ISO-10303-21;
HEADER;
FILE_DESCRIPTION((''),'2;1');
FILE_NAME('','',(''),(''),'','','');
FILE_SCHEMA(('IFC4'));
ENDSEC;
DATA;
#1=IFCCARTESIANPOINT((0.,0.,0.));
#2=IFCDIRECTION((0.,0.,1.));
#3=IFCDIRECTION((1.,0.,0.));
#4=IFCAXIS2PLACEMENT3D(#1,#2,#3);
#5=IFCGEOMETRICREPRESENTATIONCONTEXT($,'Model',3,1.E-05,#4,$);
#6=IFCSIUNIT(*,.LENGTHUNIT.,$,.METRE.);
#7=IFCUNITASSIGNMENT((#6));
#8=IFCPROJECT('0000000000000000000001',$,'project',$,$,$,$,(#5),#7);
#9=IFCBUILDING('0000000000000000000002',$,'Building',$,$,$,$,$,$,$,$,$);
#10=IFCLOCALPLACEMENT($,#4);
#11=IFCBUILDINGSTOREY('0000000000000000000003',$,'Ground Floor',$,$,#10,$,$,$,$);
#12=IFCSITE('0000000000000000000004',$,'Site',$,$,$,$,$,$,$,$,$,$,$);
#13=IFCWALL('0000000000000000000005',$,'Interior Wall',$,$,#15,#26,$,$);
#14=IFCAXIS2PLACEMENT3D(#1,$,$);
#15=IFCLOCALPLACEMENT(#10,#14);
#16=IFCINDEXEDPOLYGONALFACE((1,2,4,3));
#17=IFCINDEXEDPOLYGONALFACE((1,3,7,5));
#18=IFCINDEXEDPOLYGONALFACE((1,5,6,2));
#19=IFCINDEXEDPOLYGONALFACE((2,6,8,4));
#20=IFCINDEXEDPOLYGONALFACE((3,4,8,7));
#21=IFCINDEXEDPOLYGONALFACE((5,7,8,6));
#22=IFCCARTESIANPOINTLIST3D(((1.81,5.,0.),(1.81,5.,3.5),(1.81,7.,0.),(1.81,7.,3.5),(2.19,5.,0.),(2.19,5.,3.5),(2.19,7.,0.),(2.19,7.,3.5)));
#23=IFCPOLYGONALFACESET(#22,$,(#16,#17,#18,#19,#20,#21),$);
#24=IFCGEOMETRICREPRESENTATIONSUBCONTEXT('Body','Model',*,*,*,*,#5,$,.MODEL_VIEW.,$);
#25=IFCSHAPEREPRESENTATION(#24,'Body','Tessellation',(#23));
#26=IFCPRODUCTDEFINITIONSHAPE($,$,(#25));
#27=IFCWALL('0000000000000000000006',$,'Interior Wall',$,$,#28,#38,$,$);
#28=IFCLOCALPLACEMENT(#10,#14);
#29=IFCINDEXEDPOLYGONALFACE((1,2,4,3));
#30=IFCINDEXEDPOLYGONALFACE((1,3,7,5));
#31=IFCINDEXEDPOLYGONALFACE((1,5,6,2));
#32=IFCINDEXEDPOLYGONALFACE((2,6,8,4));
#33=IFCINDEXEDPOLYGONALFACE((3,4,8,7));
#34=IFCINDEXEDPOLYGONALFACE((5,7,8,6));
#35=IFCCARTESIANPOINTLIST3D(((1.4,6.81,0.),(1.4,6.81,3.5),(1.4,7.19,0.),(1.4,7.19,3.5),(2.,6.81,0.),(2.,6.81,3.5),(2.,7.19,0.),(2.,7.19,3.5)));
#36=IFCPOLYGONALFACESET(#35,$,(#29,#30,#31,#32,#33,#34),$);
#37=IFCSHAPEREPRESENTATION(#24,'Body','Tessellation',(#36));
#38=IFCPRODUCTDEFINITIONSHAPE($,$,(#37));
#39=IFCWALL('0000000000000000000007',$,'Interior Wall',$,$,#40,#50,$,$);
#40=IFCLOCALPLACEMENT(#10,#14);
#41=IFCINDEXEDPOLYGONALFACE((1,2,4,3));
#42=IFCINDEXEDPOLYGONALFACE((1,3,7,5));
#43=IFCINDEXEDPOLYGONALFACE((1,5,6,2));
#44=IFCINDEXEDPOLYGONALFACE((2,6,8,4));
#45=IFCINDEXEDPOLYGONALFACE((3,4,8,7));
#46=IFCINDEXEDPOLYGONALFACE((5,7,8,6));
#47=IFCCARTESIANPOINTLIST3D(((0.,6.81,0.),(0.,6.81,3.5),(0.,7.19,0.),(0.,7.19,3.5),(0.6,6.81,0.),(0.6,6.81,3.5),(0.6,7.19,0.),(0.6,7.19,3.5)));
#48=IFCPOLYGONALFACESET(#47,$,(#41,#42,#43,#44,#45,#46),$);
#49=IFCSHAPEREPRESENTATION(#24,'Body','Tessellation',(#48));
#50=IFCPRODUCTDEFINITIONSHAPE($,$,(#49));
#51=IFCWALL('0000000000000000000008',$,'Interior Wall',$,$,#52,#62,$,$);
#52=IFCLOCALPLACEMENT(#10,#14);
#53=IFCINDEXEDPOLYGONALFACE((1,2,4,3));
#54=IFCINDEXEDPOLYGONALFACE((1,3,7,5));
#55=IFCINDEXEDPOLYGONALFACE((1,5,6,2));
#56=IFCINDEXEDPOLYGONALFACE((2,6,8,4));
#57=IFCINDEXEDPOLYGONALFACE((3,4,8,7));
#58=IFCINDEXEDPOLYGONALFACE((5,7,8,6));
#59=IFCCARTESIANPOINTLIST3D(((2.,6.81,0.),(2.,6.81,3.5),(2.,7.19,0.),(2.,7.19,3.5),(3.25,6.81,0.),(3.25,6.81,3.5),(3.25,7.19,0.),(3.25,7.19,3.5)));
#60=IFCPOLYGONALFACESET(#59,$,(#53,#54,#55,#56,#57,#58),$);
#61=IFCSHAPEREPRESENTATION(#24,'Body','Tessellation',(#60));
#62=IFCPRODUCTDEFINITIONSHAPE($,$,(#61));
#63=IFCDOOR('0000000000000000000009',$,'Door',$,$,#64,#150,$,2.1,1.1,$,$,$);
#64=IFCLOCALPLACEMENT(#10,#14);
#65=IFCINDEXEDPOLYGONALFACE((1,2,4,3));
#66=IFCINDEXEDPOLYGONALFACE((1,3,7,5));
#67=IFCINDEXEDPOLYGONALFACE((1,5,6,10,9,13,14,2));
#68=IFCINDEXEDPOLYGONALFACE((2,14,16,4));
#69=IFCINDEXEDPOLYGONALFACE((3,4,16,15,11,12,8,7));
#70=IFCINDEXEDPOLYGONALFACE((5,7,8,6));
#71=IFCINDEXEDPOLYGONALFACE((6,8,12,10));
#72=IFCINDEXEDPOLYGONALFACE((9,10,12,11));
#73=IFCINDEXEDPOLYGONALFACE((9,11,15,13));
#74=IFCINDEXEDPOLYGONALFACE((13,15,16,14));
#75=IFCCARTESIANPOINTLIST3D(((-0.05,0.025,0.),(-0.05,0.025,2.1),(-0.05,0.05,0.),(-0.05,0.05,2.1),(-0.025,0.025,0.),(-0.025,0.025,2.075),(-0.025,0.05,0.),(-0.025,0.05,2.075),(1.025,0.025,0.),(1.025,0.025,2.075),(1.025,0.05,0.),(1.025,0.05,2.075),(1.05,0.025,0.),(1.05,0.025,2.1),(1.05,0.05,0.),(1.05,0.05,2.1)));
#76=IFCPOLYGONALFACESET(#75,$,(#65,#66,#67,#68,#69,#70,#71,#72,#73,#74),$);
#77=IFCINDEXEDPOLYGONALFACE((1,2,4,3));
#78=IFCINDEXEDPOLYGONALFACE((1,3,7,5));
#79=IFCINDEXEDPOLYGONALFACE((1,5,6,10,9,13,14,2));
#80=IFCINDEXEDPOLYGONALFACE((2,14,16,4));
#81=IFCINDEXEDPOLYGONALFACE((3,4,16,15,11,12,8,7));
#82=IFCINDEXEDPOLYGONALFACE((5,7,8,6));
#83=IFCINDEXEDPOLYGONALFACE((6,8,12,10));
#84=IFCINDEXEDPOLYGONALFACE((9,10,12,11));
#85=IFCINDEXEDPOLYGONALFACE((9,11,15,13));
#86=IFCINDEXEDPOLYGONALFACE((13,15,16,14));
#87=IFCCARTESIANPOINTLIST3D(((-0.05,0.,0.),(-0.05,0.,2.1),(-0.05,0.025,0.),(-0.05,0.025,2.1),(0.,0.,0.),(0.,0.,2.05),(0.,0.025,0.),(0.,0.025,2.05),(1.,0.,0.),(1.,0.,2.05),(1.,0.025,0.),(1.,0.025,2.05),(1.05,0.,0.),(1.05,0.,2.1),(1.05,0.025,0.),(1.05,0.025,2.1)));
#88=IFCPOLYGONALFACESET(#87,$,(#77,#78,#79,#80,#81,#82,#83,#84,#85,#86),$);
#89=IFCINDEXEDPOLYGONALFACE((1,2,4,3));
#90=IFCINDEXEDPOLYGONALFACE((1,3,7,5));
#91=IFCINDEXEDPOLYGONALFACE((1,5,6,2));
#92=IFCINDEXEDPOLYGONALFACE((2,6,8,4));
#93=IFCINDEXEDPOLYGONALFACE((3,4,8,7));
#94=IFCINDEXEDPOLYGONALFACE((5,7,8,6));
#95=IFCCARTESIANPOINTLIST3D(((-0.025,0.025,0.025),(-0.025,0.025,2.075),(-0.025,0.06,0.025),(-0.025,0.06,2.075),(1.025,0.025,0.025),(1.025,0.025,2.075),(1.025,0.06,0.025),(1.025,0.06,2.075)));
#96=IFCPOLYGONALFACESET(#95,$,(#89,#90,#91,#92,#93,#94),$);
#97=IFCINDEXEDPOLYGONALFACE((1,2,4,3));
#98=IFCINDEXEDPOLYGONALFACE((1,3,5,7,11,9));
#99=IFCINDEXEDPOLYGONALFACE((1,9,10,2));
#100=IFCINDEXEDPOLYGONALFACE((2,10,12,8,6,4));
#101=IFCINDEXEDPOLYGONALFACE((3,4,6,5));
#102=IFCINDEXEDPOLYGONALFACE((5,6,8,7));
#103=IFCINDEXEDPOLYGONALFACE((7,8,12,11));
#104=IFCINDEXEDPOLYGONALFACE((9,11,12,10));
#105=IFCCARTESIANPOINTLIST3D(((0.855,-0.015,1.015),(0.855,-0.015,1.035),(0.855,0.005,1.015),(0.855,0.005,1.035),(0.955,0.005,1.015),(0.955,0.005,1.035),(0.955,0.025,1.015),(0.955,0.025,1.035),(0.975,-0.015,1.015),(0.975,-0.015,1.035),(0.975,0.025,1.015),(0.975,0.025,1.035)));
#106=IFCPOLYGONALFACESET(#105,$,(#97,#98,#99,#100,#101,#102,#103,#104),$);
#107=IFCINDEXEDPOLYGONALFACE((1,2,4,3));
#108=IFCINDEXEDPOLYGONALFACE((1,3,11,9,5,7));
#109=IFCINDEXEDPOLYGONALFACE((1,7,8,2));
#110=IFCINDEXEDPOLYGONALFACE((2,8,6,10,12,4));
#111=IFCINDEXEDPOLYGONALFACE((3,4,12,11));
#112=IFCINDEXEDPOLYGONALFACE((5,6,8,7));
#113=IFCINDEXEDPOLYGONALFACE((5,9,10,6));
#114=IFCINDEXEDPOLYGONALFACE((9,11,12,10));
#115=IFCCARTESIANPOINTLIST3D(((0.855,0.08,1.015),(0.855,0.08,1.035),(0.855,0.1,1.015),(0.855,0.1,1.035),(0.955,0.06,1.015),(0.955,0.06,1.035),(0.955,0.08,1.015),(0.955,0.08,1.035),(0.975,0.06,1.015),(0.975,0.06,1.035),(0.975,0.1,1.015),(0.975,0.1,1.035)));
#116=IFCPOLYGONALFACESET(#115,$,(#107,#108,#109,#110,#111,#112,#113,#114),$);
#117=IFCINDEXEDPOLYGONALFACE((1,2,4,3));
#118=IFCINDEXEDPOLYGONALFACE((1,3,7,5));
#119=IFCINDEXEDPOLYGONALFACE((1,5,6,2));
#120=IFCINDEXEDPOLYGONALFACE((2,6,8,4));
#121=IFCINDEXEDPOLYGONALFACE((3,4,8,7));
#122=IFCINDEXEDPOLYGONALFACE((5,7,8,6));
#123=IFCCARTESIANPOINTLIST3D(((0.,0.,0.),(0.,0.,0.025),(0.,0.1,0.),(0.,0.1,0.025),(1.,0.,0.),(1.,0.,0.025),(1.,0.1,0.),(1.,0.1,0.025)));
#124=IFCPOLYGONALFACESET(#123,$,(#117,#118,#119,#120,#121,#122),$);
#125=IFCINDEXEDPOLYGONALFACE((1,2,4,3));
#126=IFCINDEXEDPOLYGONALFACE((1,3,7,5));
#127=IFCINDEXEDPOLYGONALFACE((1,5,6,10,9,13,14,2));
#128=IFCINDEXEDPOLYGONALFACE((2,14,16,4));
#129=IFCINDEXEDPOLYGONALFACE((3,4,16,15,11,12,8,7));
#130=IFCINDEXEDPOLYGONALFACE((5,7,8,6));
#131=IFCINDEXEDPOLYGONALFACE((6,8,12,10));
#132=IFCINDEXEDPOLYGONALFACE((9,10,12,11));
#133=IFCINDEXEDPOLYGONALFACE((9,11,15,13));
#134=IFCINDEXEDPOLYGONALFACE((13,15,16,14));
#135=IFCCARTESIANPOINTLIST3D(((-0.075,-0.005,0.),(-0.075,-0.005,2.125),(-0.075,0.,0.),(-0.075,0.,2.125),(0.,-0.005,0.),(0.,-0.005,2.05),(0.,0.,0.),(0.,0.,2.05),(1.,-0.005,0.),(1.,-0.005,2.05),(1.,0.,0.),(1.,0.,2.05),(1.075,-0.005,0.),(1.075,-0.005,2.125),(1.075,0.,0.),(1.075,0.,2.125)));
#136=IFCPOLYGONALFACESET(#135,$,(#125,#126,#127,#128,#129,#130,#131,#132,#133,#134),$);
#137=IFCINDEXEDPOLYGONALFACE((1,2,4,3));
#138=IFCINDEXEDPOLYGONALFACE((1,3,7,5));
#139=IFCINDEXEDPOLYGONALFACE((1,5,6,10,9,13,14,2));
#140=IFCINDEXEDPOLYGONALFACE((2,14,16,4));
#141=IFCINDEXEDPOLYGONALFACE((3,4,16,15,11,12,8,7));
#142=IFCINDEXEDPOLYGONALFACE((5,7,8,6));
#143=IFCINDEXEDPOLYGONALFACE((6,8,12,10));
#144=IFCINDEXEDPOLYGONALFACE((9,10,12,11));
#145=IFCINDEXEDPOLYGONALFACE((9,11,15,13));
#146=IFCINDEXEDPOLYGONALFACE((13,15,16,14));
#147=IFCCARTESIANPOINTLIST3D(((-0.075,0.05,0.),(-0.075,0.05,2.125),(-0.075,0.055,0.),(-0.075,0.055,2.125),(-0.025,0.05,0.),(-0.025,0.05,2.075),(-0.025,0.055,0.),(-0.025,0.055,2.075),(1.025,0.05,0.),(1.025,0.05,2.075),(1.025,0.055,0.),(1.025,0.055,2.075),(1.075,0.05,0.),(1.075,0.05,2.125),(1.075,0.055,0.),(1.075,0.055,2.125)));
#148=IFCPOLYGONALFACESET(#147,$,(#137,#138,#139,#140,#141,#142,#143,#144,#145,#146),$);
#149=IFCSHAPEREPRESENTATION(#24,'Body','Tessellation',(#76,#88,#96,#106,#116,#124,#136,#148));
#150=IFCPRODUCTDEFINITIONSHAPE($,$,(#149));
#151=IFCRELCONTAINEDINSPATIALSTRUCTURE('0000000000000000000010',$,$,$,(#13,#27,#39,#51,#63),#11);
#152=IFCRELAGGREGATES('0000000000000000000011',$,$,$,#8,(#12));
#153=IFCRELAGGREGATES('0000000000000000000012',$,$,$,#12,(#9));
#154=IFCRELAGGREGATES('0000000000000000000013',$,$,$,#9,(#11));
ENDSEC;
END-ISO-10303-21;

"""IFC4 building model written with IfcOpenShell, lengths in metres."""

from ifc_helpers import new_model, si_unit, frame, origin_with_axes, place, context, subcontext, project, spatial, line, indexed_curve, outline, extrude, element, save


model = new_model("IFC4")

# Units and contexts
model_context = context("Model", 3, precision=1e-05, world=origin_with_axes())
body_context = subcontext(model_context, "Body", "Model", "MODEL_VIEW")
ifc_project = project(units=[si_unit("LENGTHUNIT", "METRE")], contexts=[model_context])

# Site, building, storey
site = spatial("IfcSite", under=ifc_project, Name="Site")
building = spatial("IfcBuilding", under=site, Name="Building")
storey_placement = place(None, origin_with_axes())
storey = spatial("IfcBuildingStorey", under=building, at=storey_placement, Name="Ground Floor")

# Walls
wall_1_placement = place(storey_placement, frame((2.0, 5.0, 0.0), z_axis=(0.0, 0.0, 1.0), x_axis=(0.0, 1.0, 0.0)))
element("IfcWall", 1, at=wall_1_placement, inside=storey, Name="Interior Wall", context=body_context, shape_type="SweptSolid", body=[
    extrude(outline(indexed_curve([(0.0, 0.0), (0.0, 0.38), (2.0, 0.38), (2.0, 0.0), (0.0, 0.0)], self_intersect=False)), frame((0.0, -0.19, 0.0), z_axis=(0.0, 0.0, 1.0), x_axis=(1.0, 0.0, 0.0)), (0.0, 0.0, 1.0), 3.5),
])
for number, where, z_axis, x_axis, name in (
    (2, (2.0, 7.0, 0.0), (0.0, 0.0, 1.0), (-1.0, 0.0, 0.0), "Interior Wall"),
    (3, (0.6, 7.0, 0.0), (0.0, 0.0, 1.0), (-1.0, 0.0, 0.0), "Interior Wall"),
):
    element("IfcWall", number, at=place(storey_placement, frame(where, z_axis=z_axis, x_axis=x_axis)), inside=storey, Name=name, context=body_context, shape_type="SweptSolid", body=[
        extrude(outline(indexed_curve([(0.0, 0.0), (0.0, 0.38), (0.6, 0.38), (0.6, 0.0), (0.0, 0.0)], self_intersect=False)), frame((0.0, -0.19, 0.0), z_axis=(0.0, 0.0, 1.0), x_axis=(1.0, 0.0, 0.0)), (0.0, 0.0, 1.0), 3.5),
    ])
wall_2_placement = place(storey_placement, frame((3.25, 7.0, 0.0), z_axis=(0.0, 0.0, 1.0), x_axis=(-1.0, 0.0, 0.0)))
element("IfcWall", 4, at=wall_2_placement, inside=storey, Name="Interior Wall", context=body_context, shape_type="SweptSolid", body=[
    extrude(outline(indexed_curve([(0.0, 0.0), (0.0, 0.38), (1.25, 0.38), (1.25, 0.0), (0.0, 0.0)], self_intersect=False)), frame((0.0, -0.19, 0.0), z_axis=(0.0, 0.0, 1.0), x_axis=(1.0, 0.0, 0.0)), (0.0, 0.0, 1.0), 3.5),
])

# Door
door_1_placement = place(storey_placement, frame((-0.05, 0.0, 0.0), z_axis=(0.0, 0.0, 1.0), x_axis=(1.0, 0.0, 0.0)))
element("IfcDoor", 5, at=door_1_placement, inside=storey, Name="Door", OverallHeight=2.1, OverallWidth=1.1, context=body_context, shape_type="SweptSolid", body=[
    extrude(outline(indexed_curve([(0.0, 0.0), (0.0, 2.1), (1.1, 2.1), (1.1, 0.0), (1.075, 0.0), (1.075, 2.075), (0.025, 2.075), (0.025, 0.0)], segments=[line(1, 2, 3, 4, 5, 6, 7, 8, 1)])), frame((0.0, 0.025, 0.0), z_axis=(0.0, -1.0, 0.0), x_axis=(1.0, 0.0, 0.0)), (0.0, 0.0, -1.0), 0.025),
    extrude(outline(indexed_curve([(0.0, 0.0), (0.0, 2.1), (1.1, 2.1), (1.1, 0.0), (1.05, 0.0), (1.05, 2.05), (0.05, 2.05), (0.05, 0.0)], segments=[line(1, 2, 3, 4, 5, 6, 7, 8, 1)])), frame((0.0, 0.0, 0.0), z_axis=(0.0, -1.0, 0.0), x_axis=(1.0, 0.0, 0.0)), (0.0, 0.0, -1.0), 0.025),
    extrude(outline(indexed_curve([(0.0, 0.0), (1.05, 0.0), (1.05, 0.035), (0.0, 0.035)], segments=[line(1, 2, 3, 4, 1)])), frame((0.025, 0.025, 0.025), z_axis=(0.0, 0.0, 1.0), x_axis=(1.0, 0.0, 0.0)), (0.0, 0.0, 1.0), 2.05),
    extrude(outline(indexed_curve([(0.0, 0.0), (0.0, -0.04), (-0.12, -0.04), (-0.12, -0.02), (-0.02, -0.02), (-0.02, 0.0)], segments=[line(1, 2, 3, 4, 5, 6, 1)])), frame((1.025, 0.025, 1.015), z_axis=(0.0, 0.0, 1.0), x_axis=(1.0, 0.0, 0.0)), (0.0, 0.0, 1.0), 0.02),
    extrude(outline(indexed_curve([(0.0, 0.0), (0.0, 0.04), (-0.12, 0.04), (-0.12, 0.02), (-0.02, 0.02), (-0.02, 0.0)], segments=[line(1, 2, 3, 4, 5, 6, 1)])), frame((1.025, 0.06, 1.015), z_axis=(0.0, 0.0, 1.0), x_axis=(1.0, 0.0, 0.0)), (0.0, 0.0, 1.0), 0.02),
    extrude(outline(indexed_curve([(0.0, 0.0), (1.0, 0.0), (1.0, 0.1), (0.0, 0.1)], segments=[line(1, 2, 3, 4, 1)])), frame((0.05, 0.0, 0.0), z_axis=(0.0, 0.0, 1.0), x_axis=(1.0, 0.0, 0.0)), (0.0, 0.0, 1.0), 0.025),
    extrude(outline(indexed_curve([(0.0, 0.0), (0.0, 2.125), (1.15, 2.125), (1.15, 0.0), (1.075, 0.0), (1.075, 2.05), (0.075, 2.05), (0.075, 0.0)], segments=[line(1, 2, 3, 4, 5, 6, 7, 8, 1)])), frame((-0.025, -0.005, 0.0), z_axis=(0.0, -1.0, 0.0), x_axis=(1.0, 0.0, 0.0)), (0.0, 0.0, -1.0), 0.005),
    extrude(outline(indexed_curve([(0.0, 0.0), (0.0, 2.125), (1.15, 2.125), (1.15, 0.0), (1.1, 0.0), (1.1, 2.075), (0.05, 2.075), (0.05, 0.0)], segments=[line(1, 2, 3, 4, 5, 6, 7, 8, 1)])), frame((-0.025, 0.05, 0.0), z_axis=(0.0, -1.0, 0.0), x_axis=(1.0, 0.0, 0.0)), (0.0, 0.0, -1.0), 0.005),
])

save(model, "model.ifc")
